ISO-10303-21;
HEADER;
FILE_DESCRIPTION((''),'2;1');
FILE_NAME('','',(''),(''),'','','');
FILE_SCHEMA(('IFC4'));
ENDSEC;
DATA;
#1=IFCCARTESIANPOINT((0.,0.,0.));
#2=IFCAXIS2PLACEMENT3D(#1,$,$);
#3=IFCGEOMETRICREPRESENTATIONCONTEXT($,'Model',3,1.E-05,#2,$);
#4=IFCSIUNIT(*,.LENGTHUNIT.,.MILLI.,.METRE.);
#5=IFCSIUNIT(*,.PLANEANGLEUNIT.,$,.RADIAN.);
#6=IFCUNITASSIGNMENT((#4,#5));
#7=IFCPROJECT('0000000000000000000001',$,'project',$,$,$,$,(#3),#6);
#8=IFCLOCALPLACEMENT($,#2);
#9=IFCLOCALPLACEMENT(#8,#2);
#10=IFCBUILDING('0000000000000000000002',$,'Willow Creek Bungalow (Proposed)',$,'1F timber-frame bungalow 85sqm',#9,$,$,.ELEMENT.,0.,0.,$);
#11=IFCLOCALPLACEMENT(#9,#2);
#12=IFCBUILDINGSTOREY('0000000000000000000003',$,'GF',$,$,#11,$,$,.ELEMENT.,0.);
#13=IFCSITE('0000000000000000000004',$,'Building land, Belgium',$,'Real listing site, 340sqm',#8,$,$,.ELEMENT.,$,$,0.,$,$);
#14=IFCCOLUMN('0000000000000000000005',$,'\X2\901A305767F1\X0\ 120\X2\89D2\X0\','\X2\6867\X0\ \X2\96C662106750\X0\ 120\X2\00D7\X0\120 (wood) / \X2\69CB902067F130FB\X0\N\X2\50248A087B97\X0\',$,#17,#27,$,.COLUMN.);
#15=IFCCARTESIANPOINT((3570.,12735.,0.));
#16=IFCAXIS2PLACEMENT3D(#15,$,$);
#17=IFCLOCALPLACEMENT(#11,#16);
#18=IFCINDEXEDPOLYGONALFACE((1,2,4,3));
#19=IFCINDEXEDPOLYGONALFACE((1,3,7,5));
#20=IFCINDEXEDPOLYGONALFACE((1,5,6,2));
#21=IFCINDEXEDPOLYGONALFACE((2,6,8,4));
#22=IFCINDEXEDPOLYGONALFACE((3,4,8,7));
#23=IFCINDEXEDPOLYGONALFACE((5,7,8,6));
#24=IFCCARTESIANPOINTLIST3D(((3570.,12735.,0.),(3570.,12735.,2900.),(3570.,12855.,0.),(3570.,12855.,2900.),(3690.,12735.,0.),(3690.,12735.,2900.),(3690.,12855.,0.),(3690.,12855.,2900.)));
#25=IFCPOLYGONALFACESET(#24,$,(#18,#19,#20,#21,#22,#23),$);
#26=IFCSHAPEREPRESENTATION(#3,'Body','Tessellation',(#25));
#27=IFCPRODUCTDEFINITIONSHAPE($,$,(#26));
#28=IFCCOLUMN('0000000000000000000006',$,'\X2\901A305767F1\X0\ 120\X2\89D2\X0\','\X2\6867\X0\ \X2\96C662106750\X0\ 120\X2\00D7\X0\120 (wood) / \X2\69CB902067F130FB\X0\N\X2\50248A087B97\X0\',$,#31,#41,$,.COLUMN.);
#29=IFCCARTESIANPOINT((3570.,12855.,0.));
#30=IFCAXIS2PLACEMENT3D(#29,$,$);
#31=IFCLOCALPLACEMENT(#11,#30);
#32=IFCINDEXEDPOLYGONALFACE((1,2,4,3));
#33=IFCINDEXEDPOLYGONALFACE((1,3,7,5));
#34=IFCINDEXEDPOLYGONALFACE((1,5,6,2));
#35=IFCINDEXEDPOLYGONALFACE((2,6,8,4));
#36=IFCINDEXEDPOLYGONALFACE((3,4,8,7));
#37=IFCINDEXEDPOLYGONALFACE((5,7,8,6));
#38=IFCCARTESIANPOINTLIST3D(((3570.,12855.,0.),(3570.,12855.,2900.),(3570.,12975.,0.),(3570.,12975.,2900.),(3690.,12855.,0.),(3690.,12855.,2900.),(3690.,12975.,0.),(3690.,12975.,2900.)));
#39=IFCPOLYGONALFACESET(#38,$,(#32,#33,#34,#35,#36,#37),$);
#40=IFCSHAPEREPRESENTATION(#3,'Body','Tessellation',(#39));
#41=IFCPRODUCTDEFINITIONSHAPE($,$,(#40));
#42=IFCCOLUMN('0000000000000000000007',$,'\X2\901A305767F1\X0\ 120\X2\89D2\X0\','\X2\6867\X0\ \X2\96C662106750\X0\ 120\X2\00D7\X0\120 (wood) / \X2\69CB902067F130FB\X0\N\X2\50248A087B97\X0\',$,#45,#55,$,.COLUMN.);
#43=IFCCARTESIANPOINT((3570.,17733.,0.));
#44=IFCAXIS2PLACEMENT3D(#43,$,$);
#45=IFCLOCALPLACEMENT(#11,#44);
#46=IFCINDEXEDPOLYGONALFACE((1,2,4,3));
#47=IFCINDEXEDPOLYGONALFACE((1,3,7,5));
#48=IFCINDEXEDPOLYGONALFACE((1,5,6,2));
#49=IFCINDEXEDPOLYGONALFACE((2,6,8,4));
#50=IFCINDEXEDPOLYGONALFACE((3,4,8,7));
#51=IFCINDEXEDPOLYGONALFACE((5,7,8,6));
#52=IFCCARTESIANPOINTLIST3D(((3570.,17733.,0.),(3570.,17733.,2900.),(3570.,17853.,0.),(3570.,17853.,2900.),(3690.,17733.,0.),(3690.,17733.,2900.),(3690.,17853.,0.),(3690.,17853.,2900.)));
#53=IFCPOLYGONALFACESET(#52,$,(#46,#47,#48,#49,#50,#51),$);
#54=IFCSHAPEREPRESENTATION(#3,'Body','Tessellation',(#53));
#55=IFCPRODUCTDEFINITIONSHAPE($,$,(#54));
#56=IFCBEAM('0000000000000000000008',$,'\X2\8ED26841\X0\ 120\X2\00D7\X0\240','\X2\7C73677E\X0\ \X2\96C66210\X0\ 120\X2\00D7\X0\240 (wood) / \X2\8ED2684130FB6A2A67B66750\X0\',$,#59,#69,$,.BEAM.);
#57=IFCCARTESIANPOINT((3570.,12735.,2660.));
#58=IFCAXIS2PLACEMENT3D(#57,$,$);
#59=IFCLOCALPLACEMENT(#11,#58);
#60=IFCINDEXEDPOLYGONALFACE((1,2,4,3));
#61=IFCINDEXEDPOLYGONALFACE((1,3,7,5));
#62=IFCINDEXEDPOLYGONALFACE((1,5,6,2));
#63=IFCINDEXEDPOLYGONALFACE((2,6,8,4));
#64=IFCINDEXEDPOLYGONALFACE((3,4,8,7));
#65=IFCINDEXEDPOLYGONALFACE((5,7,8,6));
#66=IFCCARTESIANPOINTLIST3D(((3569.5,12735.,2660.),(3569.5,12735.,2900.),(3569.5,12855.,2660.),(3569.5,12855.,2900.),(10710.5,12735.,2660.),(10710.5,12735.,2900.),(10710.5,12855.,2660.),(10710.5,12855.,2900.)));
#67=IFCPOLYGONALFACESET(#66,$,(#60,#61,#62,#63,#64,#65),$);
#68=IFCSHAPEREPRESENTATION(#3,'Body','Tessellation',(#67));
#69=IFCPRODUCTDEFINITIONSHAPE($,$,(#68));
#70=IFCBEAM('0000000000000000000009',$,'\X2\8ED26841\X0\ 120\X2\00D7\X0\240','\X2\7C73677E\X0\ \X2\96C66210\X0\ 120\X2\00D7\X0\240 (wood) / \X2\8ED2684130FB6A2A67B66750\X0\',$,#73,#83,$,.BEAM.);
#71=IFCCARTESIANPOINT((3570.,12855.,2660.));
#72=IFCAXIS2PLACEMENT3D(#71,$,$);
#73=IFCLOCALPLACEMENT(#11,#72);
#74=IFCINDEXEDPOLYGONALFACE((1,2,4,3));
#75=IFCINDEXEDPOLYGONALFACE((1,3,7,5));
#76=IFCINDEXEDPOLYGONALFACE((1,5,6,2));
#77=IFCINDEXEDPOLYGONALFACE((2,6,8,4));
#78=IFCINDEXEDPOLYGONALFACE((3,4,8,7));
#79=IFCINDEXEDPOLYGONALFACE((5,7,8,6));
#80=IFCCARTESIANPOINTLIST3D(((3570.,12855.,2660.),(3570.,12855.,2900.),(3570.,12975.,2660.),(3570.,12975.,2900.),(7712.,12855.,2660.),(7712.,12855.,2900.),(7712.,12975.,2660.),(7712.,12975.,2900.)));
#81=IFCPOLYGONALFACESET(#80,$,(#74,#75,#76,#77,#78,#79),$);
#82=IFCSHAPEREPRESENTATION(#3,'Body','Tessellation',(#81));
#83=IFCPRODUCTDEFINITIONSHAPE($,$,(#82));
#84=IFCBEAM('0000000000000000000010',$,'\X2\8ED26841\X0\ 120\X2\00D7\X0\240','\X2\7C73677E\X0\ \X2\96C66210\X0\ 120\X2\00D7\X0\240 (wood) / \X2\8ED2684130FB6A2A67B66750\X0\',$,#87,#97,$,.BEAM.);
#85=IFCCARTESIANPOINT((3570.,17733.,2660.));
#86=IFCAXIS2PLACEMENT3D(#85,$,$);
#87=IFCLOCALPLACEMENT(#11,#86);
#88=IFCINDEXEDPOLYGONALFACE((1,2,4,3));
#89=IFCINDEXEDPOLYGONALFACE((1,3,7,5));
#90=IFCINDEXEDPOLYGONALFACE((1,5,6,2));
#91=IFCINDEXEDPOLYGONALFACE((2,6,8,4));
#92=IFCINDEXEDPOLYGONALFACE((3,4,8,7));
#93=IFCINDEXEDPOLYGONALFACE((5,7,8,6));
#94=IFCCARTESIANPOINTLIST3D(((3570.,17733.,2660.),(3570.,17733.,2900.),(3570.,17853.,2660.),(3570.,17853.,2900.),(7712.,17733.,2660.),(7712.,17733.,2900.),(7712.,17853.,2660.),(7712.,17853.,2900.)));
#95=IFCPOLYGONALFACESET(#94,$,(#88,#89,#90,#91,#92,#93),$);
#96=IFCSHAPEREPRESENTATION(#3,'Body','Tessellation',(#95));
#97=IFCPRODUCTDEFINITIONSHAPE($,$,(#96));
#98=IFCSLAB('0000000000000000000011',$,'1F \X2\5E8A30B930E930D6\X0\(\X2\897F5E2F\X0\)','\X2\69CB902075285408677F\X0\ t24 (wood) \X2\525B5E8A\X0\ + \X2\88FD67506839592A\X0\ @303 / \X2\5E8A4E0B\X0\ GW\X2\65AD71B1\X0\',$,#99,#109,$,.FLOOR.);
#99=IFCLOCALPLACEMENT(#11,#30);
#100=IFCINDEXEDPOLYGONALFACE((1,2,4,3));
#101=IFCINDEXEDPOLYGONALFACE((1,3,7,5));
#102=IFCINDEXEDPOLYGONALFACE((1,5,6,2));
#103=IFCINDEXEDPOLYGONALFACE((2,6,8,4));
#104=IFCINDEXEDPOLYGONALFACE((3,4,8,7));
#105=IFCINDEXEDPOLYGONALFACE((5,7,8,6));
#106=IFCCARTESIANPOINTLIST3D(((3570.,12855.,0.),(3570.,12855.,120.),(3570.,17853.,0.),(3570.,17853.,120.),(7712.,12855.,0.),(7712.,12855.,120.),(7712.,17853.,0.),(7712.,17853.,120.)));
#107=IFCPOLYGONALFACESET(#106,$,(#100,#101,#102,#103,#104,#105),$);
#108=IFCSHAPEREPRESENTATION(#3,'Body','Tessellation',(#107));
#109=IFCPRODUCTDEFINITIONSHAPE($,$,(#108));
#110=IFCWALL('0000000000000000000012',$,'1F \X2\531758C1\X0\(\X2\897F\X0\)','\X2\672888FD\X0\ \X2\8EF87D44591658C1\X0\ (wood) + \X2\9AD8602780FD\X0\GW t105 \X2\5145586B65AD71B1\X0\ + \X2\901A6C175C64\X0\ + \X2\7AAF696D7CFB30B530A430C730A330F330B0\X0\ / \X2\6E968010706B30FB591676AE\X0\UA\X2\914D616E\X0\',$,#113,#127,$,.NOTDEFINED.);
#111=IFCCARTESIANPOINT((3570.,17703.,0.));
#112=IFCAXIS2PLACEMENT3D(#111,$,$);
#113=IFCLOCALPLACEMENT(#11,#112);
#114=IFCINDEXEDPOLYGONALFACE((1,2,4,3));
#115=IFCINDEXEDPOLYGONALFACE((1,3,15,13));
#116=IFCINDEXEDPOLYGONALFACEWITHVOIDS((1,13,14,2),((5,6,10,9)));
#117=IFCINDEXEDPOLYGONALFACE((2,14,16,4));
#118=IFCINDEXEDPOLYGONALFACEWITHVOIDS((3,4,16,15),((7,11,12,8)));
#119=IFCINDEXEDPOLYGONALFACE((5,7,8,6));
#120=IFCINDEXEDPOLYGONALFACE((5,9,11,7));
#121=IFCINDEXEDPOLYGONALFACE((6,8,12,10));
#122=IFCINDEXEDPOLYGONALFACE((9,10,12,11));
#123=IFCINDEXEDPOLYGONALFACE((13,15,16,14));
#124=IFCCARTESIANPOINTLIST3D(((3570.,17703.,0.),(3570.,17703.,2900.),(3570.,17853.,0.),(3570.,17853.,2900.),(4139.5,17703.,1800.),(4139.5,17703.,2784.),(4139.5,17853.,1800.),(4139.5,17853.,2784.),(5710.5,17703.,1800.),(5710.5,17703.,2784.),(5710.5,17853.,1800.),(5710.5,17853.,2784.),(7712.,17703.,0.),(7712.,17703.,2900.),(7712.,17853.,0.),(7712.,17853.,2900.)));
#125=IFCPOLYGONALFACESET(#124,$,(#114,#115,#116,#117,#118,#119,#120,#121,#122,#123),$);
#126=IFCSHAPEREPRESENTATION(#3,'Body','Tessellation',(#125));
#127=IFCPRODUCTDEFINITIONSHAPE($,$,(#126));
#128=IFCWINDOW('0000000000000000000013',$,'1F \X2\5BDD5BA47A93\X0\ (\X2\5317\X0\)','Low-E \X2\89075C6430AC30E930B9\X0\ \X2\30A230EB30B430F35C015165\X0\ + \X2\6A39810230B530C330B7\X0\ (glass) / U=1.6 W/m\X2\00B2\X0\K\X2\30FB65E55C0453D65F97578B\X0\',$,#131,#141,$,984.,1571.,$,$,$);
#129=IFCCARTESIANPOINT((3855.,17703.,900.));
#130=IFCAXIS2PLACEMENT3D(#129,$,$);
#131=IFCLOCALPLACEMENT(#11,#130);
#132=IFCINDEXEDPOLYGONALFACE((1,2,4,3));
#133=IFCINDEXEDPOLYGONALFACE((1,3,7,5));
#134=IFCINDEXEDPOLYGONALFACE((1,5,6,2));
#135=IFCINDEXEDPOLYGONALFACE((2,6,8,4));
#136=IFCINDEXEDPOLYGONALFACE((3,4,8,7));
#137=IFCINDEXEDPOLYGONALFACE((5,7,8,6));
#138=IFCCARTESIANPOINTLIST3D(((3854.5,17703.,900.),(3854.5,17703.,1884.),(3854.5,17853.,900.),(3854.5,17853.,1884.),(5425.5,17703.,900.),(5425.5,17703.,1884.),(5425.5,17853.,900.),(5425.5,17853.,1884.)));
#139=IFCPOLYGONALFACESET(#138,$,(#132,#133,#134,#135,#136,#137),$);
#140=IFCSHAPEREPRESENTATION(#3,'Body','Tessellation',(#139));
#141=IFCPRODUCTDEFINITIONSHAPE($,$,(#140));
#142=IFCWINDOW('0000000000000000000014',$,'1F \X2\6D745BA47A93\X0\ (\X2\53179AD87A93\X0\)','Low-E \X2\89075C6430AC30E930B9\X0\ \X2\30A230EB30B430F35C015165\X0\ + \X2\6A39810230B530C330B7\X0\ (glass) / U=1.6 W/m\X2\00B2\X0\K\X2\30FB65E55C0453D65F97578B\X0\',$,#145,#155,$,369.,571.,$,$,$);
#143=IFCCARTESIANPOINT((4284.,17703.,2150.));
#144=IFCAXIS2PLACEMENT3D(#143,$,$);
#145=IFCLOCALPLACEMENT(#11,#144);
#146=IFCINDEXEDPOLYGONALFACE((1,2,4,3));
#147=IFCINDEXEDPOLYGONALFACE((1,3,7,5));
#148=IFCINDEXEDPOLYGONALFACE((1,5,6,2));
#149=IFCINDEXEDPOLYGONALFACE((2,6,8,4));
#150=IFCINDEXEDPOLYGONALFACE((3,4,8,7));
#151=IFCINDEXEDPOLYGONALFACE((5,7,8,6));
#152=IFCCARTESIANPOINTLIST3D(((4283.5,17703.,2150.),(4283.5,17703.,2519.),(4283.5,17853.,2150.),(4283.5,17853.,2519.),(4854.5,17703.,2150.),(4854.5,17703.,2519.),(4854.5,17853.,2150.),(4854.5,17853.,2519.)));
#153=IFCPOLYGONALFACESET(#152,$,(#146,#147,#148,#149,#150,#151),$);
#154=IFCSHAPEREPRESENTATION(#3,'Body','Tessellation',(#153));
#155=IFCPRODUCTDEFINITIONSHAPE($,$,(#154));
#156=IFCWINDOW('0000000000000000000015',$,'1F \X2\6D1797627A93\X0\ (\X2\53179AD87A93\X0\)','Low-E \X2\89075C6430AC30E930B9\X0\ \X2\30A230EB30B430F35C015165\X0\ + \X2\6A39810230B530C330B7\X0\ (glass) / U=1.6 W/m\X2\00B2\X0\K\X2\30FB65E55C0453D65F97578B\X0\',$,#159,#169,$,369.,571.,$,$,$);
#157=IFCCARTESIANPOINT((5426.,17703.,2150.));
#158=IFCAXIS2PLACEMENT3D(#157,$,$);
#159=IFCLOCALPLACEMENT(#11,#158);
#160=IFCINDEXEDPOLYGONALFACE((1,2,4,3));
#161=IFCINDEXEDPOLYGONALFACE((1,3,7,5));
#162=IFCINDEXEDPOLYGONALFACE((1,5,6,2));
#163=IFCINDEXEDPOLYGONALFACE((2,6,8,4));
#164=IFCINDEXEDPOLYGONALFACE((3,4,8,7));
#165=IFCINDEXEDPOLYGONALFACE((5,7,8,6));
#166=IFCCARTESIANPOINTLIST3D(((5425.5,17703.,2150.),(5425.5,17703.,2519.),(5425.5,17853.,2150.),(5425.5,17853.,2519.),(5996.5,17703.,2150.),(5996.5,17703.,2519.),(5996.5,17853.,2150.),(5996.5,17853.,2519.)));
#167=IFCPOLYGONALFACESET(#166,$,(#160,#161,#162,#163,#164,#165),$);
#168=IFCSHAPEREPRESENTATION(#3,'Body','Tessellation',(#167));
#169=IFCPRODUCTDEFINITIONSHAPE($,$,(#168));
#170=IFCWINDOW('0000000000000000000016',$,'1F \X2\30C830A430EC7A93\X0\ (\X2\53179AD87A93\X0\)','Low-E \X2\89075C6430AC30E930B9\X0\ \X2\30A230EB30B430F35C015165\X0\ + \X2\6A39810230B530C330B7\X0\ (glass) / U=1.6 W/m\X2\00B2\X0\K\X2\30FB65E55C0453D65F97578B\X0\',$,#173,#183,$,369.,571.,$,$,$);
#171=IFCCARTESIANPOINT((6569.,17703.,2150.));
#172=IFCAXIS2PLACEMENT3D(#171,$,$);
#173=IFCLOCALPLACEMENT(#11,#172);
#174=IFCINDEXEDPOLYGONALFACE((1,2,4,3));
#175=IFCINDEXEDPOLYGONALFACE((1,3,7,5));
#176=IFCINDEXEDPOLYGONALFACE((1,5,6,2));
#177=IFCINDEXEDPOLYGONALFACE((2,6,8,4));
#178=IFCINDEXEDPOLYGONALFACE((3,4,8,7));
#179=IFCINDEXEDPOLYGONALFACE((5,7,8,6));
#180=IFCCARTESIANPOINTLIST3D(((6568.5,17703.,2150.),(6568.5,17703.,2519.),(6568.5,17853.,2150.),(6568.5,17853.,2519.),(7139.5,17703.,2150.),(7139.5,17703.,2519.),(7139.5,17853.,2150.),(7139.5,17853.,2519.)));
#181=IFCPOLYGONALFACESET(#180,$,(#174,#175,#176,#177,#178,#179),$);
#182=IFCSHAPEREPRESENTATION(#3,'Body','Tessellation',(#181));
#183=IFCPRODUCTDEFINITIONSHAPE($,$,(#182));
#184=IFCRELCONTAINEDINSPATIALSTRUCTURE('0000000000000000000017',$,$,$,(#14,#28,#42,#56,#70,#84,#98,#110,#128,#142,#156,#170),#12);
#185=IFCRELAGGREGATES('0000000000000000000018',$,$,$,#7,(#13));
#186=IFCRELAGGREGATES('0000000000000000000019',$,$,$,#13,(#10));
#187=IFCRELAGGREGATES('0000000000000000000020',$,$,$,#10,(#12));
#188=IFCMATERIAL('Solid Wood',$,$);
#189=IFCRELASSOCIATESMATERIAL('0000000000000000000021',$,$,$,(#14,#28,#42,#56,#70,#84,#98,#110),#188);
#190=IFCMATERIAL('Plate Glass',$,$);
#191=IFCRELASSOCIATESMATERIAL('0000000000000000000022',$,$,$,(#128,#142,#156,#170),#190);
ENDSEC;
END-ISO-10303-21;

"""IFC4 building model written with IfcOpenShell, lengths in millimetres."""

from ifc_helpers import new_model, si_unit, frame, frame_2d, origin, place, context, project, spatial, rectangle, extrude, material, element, fill, save


model = new_model("IFC4")

# Units and contexts
model_context = context("Model", 3, precision=1e-05, world=origin())
ifc_project = project(units=[si_unit("LENGTHUNIT", "METRE", prefix="MILLI"), si_unit("PLANEANGLEUNIT", "RADIAN")], contexts=[model_context])

# Site, building, storey
site_placement = place(None, origin())
site = spatial("IfcSite", under=ifc_project, at=site_placement, Name="Building land, Belgium", ObjectType="Real listing site, 340sqm", CompositionType="ELEMENT", RefElevation=0.0)
building_placement = place(site_placement, origin())
building = spatial("IfcBuilding", under=site, at=building_placement, Name="Willow Creek Bungalow (Proposed)", ObjectType="1F timber-frame bungalow 85sqm", CompositionType="ELEMENT", ElevationOfRefHeight=0.0, ElevationOfTerrain=0.0)
storey_placement = place(building_placement, origin())
storey = spatial("IfcBuildingStorey", under=building, at=storey_placement, Name="GF", CompositionType="ELEMENT", Elevation=0.0)

# Columns
ifc_material_1 = material(Name="Solid Wood")
column_1_placement = place(storey_placement, frame((3570.0, 12735.0, 0.0)))
element("IfcColumn", 1, at=column_1_placement, inside=storey, material=ifc_material_1, Name="通し柱 120角", Description="桧 集成材 120×120 (wood) / 構造柱・N値計算", PredefinedType="COLUMN", context=model_context, shape_type="SweptSolid", body=[
    extrude(rectangle(XDim=120.0, YDim=120.0, at=frame_2d((60.0, 60.0))), frame((3570.0, 12735.0, 0.0)), (0.0, 0.0, 1.0), 2900.0),
])
column_2_placement = place(storey_placement, frame((3570.0, 12855.0, 0.0)))
element("IfcColumn", 2, at=column_2_placement, inside=storey, material=ifc_material_1, Name="通し柱 120角", Description="桧 集成材 120×120 (wood) / 構造柱・N値計算", PredefinedType="COLUMN", context=model_context, shape_type="SweptSolid", body=[
    extrude(rectangle(XDim=120.0, YDim=120.0, at=frame_2d((60.0, 60.0))), frame((3570.0, 12855.0, 0.0)), (0.0, 0.0, 1.0), 2900.0),
])
column_3_placement = place(storey_placement, frame((3570.0, 17733.0, 0.0)))
element("IfcColumn", 3, at=column_3_placement, inside=storey, material=ifc_material_1, Name="通し柱 120角", Description="桧 集成材 120×120 (wood) / 構造柱・N値計算", PredefinedType="COLUMN", context=model_context, shape_type="SweptSolid", body=[
    extrude(rectangle(XDim=120.0, YDim=120.0, at=frame_2d((60.0, 60.0))), frame((3570.0, 17733.0, 0.0)), (0.0, 0.0, 1.0), 2900.0),
])

# Beams
beam_1_placement = place(storey_placement, frame((3570.0, 12735.0, 2660.0)))
element("IfcBeam", 4, at=beam_1_placement, inside=storey, material=ifc_material_1, Name="軒桁 120×240", Description="米松 集成 120×240 (wood) / 軒桁・横架材", PredefinedType="BEAM", context=model_context, shape_type="SweptSolid", body=[
    extrude(rectangle(XDim=7141.0, YDim=120.0, at=frame_2d((3570.0, 60.0))), frame((3570.0, 12735.0, 2660.0)), (0.0, 0.0, 1.0), 240.0),
])
beam_2_placement = place(storey_placement, frame((3570.0, 12855.0, 2660.0)))
element("IfcBeam", 5, at=beam_2_placement, inside=storey, material=ifc_material_1, Name="軒桁 120×240", Description="米松 集成 120×240 (wood) / 軒桁・横架材", PredefinedType="BEAM", context=model_context, shape_type="SweptSolid", body=[
    extrude(rectangle(XDim=4142.0, YDim=120.0, at=frame_2d((2071.0, 60.0))), frame((3570.0, 12855.0, 2660.0)), (0.0, 0.0, 1.0), 240.0),
])
beam_3_placement = place(storey_placement, frame((3570.0, 17733.0, 2660.0)))
element("IfcBeam", 6, at=beam_3_placement, inside=storey, material=ifc_material_1, Name="軒桁 120×240", Description="米松 集成 120×240 (wood) / 軒桁・横架材", PredefinedType="BEAM", context=model_context, shape_type="SweptSolid", body=[
    extrude(rectangle(XDim=4142.0, YDim=120.0, at=frame_2d((2071.0, 60.0))), frame((3570.0, 17733.0, 2660.0)), (0.0, 0.0, 1.0), 240.0),
])

# Slab
slab_placement = place(storey_placement, frame((3570.0, 12855.0, 0.0)))
element("IfcSlab", 7, at=slab_placement, inside=storey, material=ifc_material_1, Name="1F 床スラブ(西帯)", Description="構造用合板 t24 (wood) 剛床 + 製材根太 @303 / 床下 GW断熱", PredefinedType="FLOOR", context=model_context, shape_type="SweptSolid", body=[
    extrude(rectangle(XDim=4142.0, YDim=4998.0, at=frame_2d((2071.0, 2499.0))), frame((3570.0, 12855.0, 0.0)), (0.0, 0.0, 1.0), 120.0),
])

# Wall, openings, windows
wall_1_placement = place(storey_placement, frame((3570.0, 17703.0, 0.0)))
wall_1 = element("IfcWall", 8, at=wall_1_placement, inside=storey, material=ifc_material_1, Name="1F 北壁(西)", Description="木製 軸組外壁 (wood) + 高性能GW t105 充填断熱 + 通気層 + 窯業系サイディング / 準耐火・外皮UA配慮", PredefinedType="NOTDEFINED", context=model_context, shape_type="SweptSolid", body=[
    extrude(rectangle(XDim=4142.0, YDim=150.0, at=frame_2d((2071.0, 75.0))), frame((3570.0, 17703.0, 0.0)), (0.0, 0.0, 1.0), 2900.0),
])
opening_1_placement = place(storey_placement, frame((3855.0, 17703.0, 900.0)))
opening_1 = element("IfcOpeningElement", 9, at=opening_1_placement, cuts=wall_1, PredefinedType="NOTDEFINED", context=model_context, shape_type="SweptSolid", body=[
    extrude(rectangle(XDim=1571.0, YDim=150.0, at=frame_2d((785.0, 75.0))), frame((3855.0, 17703.0, 900.0)), (0.0, 0.0, 1.0), 984.0),
])
opening_2_placement = place(storey_placement, frame((4284.0, 17703.0, 2150.0)))
opening_2 = element("IfcOpeningElement", 10, at=opening_2_placement, cuts=wall_1, PredefinedType="NOTDEFINED", context=model_context, shape_type="SweptSolid", body=[
    extrude(rectangle(XDim=571.0, YDim=150.0, at=frame_2d((285.0, 75.0))), frame((4284.0, 17703.0, 2150.0)), (0.0, 0.0, 1.0), 369.0),
])
opening_3_placement = place(storey_placement, frame((5426.0, 17703.0, 2150.0)))
opening_3 = element("IfcOpeningElement", 11, at=opening_3_placement, cuts=wall_1, PredefinedType="NOTDEFINED", context=model_context, shape_type="SweptSolid", body=[
    extrude(rectangle(XDim=571.0, YDim=150.0, at=frame_2d((285.0, 75.0))), frame((5426.0, 17703.0, 2150.0)), (0.0, 0.0, 1.0), 369.0),
])
opening_4_placement = place(storey_placement, frame((6569.0, 17703.0, 2150.0)))
opening_4 = element("IfcOpeningElement", 12, at=opening_4_placement, cuts=wall_1, PredefinedType="NOTDEFINED", context=model_context, shape_type="SweptSolid", body=[
    extrude(rectangle(XDim=571.0, YDim=150.0, at=frame_2d((285.0, 75.0))), frame((6569.0, 17703.0, 2150.0)), (0.0, 0.0, 1.0), 369.0),
])
ifc_material_2 = material(Name="Plate Glass")
window_1_placement = place(storey_placement, frame((3855.0, 17703.0, 900.0)))
window_1 = element("IfcWindow", 13, at=window_1_placement, inside=storey, material=ifc_material_2, Name="1F 寝室窓 (北)", Description="Low-E 複層ガラス アルゴン封入 + 樹脂サッシ (glass) / U=1.6 W/m²K・日射取得型", OverallHeight=984.0, OverallWidth=1571.0, context=model_context, shape_type="SweptSolid", body=[
    extrude(rectangle(XDim=1571.0, YDim=150.0, at=frame_2d((785.0, 75.0))), frame((3855.0, 17703.0, 900.0)), (0.0, 0.0, 1.0), 984.0),
])
fill(opening_1, window_1)
window_2_placement = place(storey_placement, frame((4284.0, 17703.0, 2150.0)))
window_2 = element("IfcWindow", 14, at=window_2_placement, inside=storey, material=ifc_material_2, Name="1F 浴室窓 (北高窓)", Description="Low-E 複層ガラス アルゴン封入 + 樹脂サッシ (glass) / U=1.6 W/m²K・日射取得型", OverallHeight=369.0, OverallWidth=571.0, context=model_context, shape_type="SweptSolid", body=[
    extrude(rectangle(XDim=571.0, YDim=150.0, at=frame_2d((285.0, 75.0))), frame((4284.0, 17703.0, 2150.0)), (0.0, 0.0, 1.0), 369.0),
])
fill(opening_2, window_2)
window_3_placement = place(storey_placement, frame((5426.0, 17703.0, 2150.0)))
window_3 = element("IfcWindow", 15, at=window_3_placement, inside=storey, material=ifc_material_2, Name="1F 洗面窓 (北高窓)", Description="Low-E 複層ガラス アルゴン封入 + 樹脂サッシ (glass) / U=1.6 W/m²K・日射取得型", OverallHeight=369.0, OverallWidth=571.0, context=model_context, shape_type="SweptSolid", body=[
    extrude(rectangle(XDim=571.0, YDim=150.0, at=frame_2d((285.0, 75.0))), frame((5426.0, 17703.0, 2150.0)), (0.0, 0.0, 1.0), 369.0),
])
fill(opening_3, window_3)
window_4_placement = place(storey_placement, frame((6569.0, 17703.0, 2150.0)))
window_4 = element("IfcWindow", 16, at=window_4_placement, inside=storey, material=ifc_material_2, Name="1F トイレ窓 (北高窓)", Description="Low-E 複層ガラス アルゴン封入 + 樹脂サッシ (glass) / U=1.6 W/m²K・日射取得型", OverallHeight=369.0, OverallWidth=571.0, context=model_context, shape_type="SweptSolid", body=[
    extrude(rectangle(XDim=571.0, YDim=150.0, at=frame_2d((285.0, 75.0))), frame((6569.0, 17703.0, 2150.0)), (0.0, 0.0, 1.0), 369.0),
])
fill(opening_4, window_4)

save(model, "model.ifc")
